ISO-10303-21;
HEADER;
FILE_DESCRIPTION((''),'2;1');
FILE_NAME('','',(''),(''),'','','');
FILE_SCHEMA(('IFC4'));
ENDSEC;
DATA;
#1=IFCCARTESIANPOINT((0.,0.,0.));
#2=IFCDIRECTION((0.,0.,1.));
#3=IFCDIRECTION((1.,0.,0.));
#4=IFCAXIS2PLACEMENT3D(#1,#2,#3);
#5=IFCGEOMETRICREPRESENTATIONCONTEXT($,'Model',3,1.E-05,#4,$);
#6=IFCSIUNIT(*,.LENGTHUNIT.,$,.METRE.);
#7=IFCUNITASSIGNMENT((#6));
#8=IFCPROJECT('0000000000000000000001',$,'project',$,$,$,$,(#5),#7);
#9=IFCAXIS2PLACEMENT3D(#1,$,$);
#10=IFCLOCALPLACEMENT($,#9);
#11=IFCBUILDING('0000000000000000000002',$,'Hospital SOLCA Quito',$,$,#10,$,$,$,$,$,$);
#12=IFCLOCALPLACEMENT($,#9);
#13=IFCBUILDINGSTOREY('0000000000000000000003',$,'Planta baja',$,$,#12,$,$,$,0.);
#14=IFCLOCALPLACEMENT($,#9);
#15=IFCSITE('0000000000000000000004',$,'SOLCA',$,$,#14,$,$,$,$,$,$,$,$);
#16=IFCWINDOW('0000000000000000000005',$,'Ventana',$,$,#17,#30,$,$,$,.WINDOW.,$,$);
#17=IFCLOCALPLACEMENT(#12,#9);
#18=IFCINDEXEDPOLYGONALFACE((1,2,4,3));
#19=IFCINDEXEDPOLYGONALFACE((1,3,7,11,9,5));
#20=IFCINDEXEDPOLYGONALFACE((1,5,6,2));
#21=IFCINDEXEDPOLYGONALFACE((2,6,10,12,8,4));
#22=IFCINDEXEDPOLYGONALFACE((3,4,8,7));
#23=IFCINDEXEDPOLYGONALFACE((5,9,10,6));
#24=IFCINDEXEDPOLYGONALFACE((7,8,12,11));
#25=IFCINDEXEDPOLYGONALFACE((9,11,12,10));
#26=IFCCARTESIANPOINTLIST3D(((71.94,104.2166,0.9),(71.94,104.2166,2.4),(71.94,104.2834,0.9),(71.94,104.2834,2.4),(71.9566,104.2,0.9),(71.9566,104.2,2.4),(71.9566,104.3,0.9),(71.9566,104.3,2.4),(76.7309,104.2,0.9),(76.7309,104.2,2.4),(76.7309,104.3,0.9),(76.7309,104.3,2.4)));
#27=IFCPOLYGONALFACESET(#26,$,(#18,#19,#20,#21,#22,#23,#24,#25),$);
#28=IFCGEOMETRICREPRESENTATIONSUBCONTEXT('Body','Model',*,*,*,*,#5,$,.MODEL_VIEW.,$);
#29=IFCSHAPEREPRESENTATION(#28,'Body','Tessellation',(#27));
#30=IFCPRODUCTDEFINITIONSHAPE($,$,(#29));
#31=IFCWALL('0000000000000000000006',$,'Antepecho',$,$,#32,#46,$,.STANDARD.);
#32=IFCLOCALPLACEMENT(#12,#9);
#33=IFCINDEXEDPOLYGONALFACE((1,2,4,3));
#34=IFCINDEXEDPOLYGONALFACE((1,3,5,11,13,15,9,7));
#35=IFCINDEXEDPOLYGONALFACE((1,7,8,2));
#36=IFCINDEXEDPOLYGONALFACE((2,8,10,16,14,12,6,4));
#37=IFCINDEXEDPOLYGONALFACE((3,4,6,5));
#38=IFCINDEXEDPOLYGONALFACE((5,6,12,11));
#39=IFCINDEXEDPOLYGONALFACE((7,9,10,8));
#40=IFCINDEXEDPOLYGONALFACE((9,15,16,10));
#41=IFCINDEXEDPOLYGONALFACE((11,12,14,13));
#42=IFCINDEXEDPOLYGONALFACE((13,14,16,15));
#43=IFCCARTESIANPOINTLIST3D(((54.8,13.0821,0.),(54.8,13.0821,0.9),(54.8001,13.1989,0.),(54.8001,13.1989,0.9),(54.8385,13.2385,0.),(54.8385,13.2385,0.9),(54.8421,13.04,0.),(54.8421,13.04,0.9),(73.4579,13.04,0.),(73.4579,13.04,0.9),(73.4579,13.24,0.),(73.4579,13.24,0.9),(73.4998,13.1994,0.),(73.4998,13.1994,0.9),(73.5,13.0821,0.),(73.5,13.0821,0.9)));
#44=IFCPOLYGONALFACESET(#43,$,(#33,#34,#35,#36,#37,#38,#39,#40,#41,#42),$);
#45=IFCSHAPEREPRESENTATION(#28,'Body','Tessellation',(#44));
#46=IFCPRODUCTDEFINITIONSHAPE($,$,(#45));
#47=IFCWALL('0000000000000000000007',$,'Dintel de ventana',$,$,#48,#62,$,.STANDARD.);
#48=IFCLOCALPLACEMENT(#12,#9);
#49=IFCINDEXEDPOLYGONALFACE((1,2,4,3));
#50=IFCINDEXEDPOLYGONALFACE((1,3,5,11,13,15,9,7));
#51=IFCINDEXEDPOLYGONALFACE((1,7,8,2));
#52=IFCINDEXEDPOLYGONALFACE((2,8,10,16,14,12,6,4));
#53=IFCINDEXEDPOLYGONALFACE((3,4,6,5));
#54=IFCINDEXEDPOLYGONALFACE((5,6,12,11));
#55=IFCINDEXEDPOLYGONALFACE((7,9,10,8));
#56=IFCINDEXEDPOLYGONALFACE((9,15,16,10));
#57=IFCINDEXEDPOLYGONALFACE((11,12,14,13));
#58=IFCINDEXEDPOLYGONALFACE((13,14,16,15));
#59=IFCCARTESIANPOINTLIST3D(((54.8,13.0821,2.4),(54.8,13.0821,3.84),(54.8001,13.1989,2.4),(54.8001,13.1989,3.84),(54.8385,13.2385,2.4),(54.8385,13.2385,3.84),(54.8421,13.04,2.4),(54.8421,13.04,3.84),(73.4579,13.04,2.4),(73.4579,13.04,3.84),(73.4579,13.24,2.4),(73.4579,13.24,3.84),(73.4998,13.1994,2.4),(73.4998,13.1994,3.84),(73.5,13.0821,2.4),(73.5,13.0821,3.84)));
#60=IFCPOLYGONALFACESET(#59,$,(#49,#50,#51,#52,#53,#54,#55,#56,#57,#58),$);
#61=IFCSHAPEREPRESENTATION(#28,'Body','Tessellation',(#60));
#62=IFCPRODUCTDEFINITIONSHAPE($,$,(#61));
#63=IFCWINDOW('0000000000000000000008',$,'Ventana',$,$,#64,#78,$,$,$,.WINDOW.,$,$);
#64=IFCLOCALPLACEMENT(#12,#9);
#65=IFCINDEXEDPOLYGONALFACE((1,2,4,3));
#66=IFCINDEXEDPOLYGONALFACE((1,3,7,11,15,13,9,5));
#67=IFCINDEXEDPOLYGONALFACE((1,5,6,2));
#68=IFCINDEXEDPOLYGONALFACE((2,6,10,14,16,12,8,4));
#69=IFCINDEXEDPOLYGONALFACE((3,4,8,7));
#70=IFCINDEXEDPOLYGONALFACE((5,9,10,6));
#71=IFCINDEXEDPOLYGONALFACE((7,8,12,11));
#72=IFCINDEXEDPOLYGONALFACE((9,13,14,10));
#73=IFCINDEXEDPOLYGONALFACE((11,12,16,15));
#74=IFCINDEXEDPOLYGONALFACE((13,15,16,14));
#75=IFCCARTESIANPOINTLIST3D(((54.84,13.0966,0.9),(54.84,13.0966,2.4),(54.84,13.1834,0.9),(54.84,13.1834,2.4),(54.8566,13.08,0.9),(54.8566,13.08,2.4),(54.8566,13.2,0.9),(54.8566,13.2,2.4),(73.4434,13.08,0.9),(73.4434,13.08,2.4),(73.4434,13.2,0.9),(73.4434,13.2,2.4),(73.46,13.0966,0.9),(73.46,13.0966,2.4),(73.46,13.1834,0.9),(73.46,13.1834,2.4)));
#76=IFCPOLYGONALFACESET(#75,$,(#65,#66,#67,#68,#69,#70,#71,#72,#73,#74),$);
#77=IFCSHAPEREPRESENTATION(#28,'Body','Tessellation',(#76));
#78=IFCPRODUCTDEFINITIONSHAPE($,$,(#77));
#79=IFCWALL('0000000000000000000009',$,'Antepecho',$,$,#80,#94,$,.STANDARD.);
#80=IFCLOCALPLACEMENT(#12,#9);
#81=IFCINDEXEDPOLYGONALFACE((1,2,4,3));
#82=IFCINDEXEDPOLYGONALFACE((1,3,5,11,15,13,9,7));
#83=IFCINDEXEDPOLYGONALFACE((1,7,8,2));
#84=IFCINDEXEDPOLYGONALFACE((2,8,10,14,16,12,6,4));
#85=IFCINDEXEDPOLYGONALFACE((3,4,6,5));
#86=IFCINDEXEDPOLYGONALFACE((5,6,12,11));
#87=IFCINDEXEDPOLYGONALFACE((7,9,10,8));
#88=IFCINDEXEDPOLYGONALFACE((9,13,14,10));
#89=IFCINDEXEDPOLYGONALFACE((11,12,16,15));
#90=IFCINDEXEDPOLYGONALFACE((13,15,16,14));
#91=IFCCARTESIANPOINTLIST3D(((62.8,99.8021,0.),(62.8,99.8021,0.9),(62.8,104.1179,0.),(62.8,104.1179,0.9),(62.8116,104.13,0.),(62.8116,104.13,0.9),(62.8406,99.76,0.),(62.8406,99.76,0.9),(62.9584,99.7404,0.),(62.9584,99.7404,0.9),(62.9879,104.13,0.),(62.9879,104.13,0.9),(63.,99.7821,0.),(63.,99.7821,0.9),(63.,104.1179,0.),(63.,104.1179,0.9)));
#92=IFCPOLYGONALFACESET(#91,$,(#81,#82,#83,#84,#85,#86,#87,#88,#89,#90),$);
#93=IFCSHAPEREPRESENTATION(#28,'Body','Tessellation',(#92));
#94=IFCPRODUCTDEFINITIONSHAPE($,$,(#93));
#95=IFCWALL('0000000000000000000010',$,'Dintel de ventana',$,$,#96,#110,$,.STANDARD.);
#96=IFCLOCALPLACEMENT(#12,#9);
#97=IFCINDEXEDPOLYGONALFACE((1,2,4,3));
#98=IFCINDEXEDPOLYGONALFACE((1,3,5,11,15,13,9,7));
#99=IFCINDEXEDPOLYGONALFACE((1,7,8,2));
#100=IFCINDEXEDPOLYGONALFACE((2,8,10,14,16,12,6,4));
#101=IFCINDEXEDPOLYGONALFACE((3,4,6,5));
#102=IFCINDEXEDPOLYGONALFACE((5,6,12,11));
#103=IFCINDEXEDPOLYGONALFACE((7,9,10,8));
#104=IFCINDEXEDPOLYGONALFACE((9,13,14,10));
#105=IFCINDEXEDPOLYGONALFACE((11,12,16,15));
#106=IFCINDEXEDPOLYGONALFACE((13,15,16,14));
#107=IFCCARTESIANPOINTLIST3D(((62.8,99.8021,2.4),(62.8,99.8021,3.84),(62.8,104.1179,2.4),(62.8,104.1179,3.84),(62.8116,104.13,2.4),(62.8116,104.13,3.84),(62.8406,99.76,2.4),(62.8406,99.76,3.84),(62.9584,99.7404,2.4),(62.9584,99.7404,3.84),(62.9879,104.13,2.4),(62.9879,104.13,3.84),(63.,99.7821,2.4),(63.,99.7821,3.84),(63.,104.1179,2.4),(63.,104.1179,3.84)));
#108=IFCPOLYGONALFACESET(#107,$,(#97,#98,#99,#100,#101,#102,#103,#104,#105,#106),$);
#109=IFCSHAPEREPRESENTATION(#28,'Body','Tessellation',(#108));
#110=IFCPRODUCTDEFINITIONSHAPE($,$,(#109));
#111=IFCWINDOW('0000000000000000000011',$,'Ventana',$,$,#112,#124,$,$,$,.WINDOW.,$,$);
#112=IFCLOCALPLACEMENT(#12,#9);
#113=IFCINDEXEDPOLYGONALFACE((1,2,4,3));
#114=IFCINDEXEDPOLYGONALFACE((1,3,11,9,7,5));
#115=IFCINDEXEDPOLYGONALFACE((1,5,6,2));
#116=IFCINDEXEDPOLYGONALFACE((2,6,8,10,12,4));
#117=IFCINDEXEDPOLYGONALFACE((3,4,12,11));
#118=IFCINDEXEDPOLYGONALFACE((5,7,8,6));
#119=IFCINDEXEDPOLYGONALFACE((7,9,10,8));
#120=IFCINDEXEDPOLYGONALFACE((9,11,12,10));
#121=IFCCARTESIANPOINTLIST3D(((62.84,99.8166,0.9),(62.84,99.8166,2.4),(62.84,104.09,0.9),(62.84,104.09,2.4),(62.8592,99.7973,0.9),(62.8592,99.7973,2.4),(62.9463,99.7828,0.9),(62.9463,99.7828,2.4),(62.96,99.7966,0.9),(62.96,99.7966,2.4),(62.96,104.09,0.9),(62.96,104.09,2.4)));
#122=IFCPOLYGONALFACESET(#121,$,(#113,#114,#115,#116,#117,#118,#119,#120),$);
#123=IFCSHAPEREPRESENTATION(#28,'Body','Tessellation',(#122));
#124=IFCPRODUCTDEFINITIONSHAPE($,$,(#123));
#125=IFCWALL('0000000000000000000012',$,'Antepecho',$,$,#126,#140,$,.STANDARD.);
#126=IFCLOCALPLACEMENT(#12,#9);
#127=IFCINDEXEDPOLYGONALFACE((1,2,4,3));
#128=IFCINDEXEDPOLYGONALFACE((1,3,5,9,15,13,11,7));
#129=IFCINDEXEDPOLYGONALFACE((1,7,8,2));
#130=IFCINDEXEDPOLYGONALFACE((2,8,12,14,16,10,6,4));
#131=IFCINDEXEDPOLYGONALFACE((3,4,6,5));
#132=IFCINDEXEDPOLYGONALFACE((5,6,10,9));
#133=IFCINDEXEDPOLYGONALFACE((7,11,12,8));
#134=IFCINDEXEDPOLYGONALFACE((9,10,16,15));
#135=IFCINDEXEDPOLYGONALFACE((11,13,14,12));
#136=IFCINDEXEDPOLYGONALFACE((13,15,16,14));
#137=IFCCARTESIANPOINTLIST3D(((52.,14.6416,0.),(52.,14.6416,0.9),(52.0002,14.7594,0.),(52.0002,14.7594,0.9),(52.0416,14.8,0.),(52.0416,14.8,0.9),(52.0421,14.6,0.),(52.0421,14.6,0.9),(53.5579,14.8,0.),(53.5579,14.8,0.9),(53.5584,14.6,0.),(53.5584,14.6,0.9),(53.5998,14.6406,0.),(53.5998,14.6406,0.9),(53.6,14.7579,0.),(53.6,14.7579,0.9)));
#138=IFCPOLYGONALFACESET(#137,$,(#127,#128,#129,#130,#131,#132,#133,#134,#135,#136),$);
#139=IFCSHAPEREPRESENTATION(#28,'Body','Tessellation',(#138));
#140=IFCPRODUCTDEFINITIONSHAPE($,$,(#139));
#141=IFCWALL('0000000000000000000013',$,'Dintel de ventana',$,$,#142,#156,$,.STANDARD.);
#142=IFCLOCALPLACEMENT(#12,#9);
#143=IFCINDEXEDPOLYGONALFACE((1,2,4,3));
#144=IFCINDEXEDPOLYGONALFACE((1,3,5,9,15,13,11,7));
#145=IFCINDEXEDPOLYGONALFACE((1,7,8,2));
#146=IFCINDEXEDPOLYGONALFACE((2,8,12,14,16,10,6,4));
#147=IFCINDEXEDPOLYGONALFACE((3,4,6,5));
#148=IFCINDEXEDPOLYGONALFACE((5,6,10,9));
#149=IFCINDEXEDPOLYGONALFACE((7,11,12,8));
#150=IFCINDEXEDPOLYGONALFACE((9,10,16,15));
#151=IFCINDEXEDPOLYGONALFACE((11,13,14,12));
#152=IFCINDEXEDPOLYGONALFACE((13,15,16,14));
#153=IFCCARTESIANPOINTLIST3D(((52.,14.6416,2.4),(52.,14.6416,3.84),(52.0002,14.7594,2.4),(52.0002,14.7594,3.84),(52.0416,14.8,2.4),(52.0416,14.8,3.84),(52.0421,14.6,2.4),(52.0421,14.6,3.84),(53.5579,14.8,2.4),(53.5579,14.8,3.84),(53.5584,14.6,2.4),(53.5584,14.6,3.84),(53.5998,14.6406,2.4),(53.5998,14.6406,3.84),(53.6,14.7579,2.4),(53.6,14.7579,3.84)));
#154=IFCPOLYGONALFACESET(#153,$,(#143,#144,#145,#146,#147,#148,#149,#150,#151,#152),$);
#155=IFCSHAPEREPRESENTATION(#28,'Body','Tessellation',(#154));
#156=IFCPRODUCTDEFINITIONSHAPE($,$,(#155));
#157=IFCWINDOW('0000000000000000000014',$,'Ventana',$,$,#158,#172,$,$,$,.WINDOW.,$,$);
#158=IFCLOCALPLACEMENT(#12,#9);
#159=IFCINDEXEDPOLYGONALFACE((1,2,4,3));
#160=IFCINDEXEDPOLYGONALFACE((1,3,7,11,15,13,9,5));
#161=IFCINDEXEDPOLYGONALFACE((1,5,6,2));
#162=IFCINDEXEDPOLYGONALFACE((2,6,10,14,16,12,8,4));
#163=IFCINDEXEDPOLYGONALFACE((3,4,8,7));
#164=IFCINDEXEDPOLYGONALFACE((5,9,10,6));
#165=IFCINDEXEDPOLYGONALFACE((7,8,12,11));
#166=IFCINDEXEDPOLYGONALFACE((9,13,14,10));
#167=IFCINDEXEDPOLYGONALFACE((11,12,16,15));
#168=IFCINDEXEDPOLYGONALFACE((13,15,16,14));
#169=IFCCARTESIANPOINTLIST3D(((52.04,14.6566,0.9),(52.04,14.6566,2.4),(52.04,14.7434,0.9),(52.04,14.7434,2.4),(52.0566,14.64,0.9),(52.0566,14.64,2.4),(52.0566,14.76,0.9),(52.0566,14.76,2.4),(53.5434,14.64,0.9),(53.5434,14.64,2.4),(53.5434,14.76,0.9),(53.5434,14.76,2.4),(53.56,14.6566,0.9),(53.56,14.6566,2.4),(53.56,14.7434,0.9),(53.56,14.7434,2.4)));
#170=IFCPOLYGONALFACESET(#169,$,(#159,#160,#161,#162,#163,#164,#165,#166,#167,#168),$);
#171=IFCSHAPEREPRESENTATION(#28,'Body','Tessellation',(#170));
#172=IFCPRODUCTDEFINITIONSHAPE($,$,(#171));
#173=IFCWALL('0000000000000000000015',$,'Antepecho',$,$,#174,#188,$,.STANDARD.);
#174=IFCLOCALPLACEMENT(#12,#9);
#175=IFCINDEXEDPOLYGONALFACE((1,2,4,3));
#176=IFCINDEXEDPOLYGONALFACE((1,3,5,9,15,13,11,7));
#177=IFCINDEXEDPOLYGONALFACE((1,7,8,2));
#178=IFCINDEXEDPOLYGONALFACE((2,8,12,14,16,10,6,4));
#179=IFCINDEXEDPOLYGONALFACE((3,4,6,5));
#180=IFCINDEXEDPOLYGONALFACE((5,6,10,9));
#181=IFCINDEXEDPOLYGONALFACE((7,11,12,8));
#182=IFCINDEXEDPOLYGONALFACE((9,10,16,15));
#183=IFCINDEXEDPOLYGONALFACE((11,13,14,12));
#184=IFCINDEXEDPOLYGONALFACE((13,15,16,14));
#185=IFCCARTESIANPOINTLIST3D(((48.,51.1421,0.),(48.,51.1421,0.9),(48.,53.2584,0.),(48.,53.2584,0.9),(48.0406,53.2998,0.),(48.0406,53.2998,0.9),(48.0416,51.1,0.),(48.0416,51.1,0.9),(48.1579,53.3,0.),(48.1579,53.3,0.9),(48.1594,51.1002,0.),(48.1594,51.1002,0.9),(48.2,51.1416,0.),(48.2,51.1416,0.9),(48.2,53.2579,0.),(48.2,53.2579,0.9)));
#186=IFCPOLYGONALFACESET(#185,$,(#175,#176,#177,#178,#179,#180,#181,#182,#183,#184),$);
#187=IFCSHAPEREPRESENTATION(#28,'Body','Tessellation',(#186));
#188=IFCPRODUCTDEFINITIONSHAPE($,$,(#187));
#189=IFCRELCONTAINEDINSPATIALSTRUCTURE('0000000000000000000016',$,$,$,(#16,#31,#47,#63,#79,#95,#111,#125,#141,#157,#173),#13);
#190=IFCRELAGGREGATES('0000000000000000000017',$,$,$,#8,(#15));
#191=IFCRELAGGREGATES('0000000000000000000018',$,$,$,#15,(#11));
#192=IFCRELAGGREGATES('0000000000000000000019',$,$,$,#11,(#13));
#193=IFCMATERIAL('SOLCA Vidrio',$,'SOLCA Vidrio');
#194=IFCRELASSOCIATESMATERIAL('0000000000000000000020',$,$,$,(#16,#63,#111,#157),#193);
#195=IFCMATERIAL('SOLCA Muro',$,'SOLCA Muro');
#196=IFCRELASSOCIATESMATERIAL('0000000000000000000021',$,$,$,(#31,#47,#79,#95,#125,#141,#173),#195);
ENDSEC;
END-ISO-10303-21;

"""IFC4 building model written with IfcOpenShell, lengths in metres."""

from ifc_helpers import new_model, si_unit, frame, origin, origin_with_axes, place, context, subcontext, project, spatial, polyline, outline, extrude, material, element, save


model = new_model("IFC4")

# Units and contexts
model_context = context("Model", 3, precision=1e-05, world=origin_with_axes())
body_context = subcontext(model_context, "Body", "Model", "MODEL_VIEW")
ifc_project = project(units=[si_unit("LENGTHUNIT", "METRE")], contexts=[model_context])

# Site, building, storey
site_placement = place(None, origin())
site = spatial("IfcSite", under=ifc_project, at=site_placement, Name="SOLCA")
building_placement = place(None, origin())
building = spatial("IfcBuilding", under=site, at=building_placement, Name="Hospital SOLCA Quito")
storey_placement = place(None, origin())
storey = spatial("IfcBuildingStorey", under=building, at=storey_placement, Name="Planta baja", Elevation=0.0)

# Shared definitions
ifc_material_1 = material(Name="SOLCA Muro", Category="SOLCA Muro")

# Shared definitions
ifc_material_2 = material(Name="SOLCA Vidrio", Category="SOLCA Vidrio")

# Window
window_1_placement = place(storey_placement, origin_with_axes())
element("IfcWindow", 1, at=window_1_placement, inside=storey, material=ifc_material_2, Name="Ventana", PredefinedType="WINDOW", context=body_context, shape_type="SweptSolid", body=[
    extrude(outline(polyline([(71.94, 104.2166), (71.94, 104.2834), (71.9566, 104.3), (76.7309, 104.3), (76.7309, 104.2), (71.9566, 104.2), (71.94, 104.2166)])), frame((0.0, 0.0, 0.9), z_axis=(0.0, 0.0, 1.0), x_axis=(1.0, 0.0, 0.0)), (0.0, 0.0, 1.0), 1.5),
])

# Walls
wall_1_placement = place(storey_placement, origin_with_axes())
element("IfcWall", 2, at=wall_1_placement, inside=storey, material=ifc_material_1, Name="Antepecho", PredefinedType="STANDARD", context=body_context, shape_type="SweptSolid", body=[
    extrude(outline(polyline([(54.8385, 13.2385), (73.4579, 13.24), (73.4998, 13.1994), (73.5, 13.0821), (73.4579, 13.04), (54.8421, 13.04), (54.8, 13.0821), (54.8001, 13.1989), (54.8385, 13.2385)])), origin_with_axes(), (0.0, 0.0, 1.0), 0.9),
])
wall_2_placement = place(storey_placement, origin_with_axes())
element("IfcWall", 3, at=wall_2_placement, inside=storey, material=ifc_material_1, Name="Dintel de ventana", PredefinedType="STANDARD", context=body_context, shape_type="SweptSolid", body=[
    extrude(outline(polyline([(54.8385, 13.2385), (73.4579, 13.24), (73.4998, 13.1994), (73.5, 13.0821), (73.4579, 13.04), (54.8421, 13.04), (54.8, 13.0821), (54.8001, 13.1989), (54.8385, 13.2385)])), frame((0.0, 0.0, 2.4), z_axis=(0.0, 0.0, 1.0), x_axis=(1.0, 0.0, 0.0)), (0.0, 0.0, 1.0), 1.44),
])

# Window
window_2_placement = place(storey_placement, origin_with_axes())
element("IfcWindow", 4, at=window_2_placement, inside=storey, material=ifc_material_2, Name="Ventana", PredefinedType="WINDOW", context=body_context, shape_type="SweptSolid", body=[
    extrude(outline(polyline([(54.84, 13.0966), (54.84, 13.1834), (54.8566, 13.2), (73.4434, 13.2), (73.46, 13.1834), (73.46, 13.0966), (73.4434, 13.08), (54.8566, 13.08), (54.84, 13.0966)])), frame((0.0, 0.0, 0.9), z_axis=(0.0, 0.0, 1.0), x_axis=(1.0, 0.0, 0.0)), (0.0, 0.0, 1.0), 1.5),
])

# Walls
wall_3_placement = place(storey_placement, origin_with_axes())
element("IfcWall", 5, at=wall_3_placement, inside=storey, material=ifc_material_1, Name="Antepecho", PredefinedType="STANDARD", context=body_context, shape_type="SweptSolid", body=[
    extrude(outline(polyline([(62.9879, 104.13), (63.0, 104.1179), (63.0, 99.7821), (62.9584, 99.7404), (62.8406, 99.76), (62.8, 99.8021), (62.8, 104.1179), (62.8116, 104.13), (62.9879, 104.13)])), origin_with_axes(), (0.0, 0.0, 1.0), 0.9),
])
wall_4_placement = place(storey_placement, origin_with_axes())
element("IfcWall", 6, at=wall_4_placement, inside=storey, material=ifc_material_1, Name="Dintel de ventana", PredefinedType="STANDARD", context=body_context, shape_type="SweptSolid", body=[
    extrude(outline(polyline([(62.9879, 104.13), (63.0, 104.1179), (63.0, 99.7821), (62.9584, 99.7404), (62.8406, 99.76), (62.8, 99.8021), (62.8, 104.1179), (62.8116, 104.13), (62.9879, 104.13)])), frame((0.0, 0.0, 2.4), z_axis=(0.0, 0.0, 1.0), x_axis=(1.0, 0.0, 0.0)), (0.0, 0.0, 1.0), 1.44),
])

# Window
window_3_placement = place(storey_placement, origin_with_axes())
element("IfcWindow", 7, at=window_3_placement, inside=storey, material=ifc_material_2, Name="Ventana", PredefinedType="WINDOW", context=body_context, shape_type="SweptSolid", body=[
    extrude(outline(polyline([(62.84, 104.09), (62.96, 104.09), (62.96, 99.7966), (62.9463, 99.7828), (62.8592, 99.7973), (62.84, 99.8166), (62.84, 104.09)])), frame((0.0, 0.0, 0.9), z_axis=(0.0, 0.0, 1.0), x_axis=(1.0, 0.0, 0.0)), (0.0, 0.0, 1.0), 1.5),
])

# Walls
wall_5_placement = place(storey_placement, origin_with_axes())
element("IfcWall", 8, at=wall_5_placement, inside=storey, material=ifc_material_1, Name="Antepecho", PredefinedType="STANDARD", context=body_context, shape_type="SweptSolid", body=[
    extrude(outline(polyline([(53.5579, 14.8), (53.6, 14.7579), (53.5998, 14.6406), (53.5584, 14.6), (52.0421, 14.6), (52.0, 14.6416), (52.0002, 14.7594), (52.0416, 14.8), (53.5579, 14.8)])), origin_with_axes(), (0.0, 0.0, 1.0), 0.9),
])
wall_6_placement = place(storey_placement, origin_with_axes())
element("IfcWall", 9, at=wall_6_placement, inside=storey, material=ifc_material_1, Name="Dintel de ventana", PredefinedType="STANDARD", context=body_context, shape_type="SweptSolid", body=[
    extrude(outline(polyline([(53.5579, 14.8), (53.6, 14.7579), (53.5998, 14.6406), (53.5584, 14.6), (52.0421, 14.6), (52.0, 14.6416), (52.0002, 14.7594), (52.0416, 14.8), (53.5579, 14.8)])), frame((0.0, 0.0, 2.4), z_axis=(0.0, 0.0, 1.0), x_axis=(1.0, 0.0, 0.0)), (0.0, 0.0, 1.0), 1.44),
])

# Window
window_4_placement = place(storey_placement, origin_with_axes())
element("IfcWindow", 10, at=window_4_placement, inside=storey, material=ifc_material_2, Name="Ventana", PredefinedType="WINDOW", context=body_context, shape_type="SweptSolid", body=[
    extrude(outline(polyline([(52.04, 14.6566), (52.04, 14.7434), (52.0566, 14.76), (53.5434, 14.76), (53.56, 14.7434), (53.56, 14.6566), (53.5434, 14.64), (52.0566, 14.64), (52.04, 14.6566)])), frame((0.0, 0.0, 0.9), z_axis=(0.0, 0.0, 1.0), x_axis=(1.0, 0.0, 0.0)), (0.0, 0.0, 1.0), 1.5),
])

# Wall
wall_7_placement = place(storey_placement, origin_with_axes())
element("IfcWall", 11, at=wall_7_placement, inside=storey, material=ifc_material_1, Name="Antepecho", PredefinedType="STANDARD", context=body_context, shape_type="SweptSolid", body=[
    extrude(outline(polyline([(48.1579, 53.3), (48.2, 53.2579), (48.2, 51.1416), (48.1594, 51.1002), (48.0416, 51.1), (48.0, 51.1421), (48.0, 53.2584), (48.0406, 53.2998), (48.1579, 53.3)])), origin_with_axes(), (0.0, 0.0, 1.0), 0.9),
])

save(model, "model.ifc")
